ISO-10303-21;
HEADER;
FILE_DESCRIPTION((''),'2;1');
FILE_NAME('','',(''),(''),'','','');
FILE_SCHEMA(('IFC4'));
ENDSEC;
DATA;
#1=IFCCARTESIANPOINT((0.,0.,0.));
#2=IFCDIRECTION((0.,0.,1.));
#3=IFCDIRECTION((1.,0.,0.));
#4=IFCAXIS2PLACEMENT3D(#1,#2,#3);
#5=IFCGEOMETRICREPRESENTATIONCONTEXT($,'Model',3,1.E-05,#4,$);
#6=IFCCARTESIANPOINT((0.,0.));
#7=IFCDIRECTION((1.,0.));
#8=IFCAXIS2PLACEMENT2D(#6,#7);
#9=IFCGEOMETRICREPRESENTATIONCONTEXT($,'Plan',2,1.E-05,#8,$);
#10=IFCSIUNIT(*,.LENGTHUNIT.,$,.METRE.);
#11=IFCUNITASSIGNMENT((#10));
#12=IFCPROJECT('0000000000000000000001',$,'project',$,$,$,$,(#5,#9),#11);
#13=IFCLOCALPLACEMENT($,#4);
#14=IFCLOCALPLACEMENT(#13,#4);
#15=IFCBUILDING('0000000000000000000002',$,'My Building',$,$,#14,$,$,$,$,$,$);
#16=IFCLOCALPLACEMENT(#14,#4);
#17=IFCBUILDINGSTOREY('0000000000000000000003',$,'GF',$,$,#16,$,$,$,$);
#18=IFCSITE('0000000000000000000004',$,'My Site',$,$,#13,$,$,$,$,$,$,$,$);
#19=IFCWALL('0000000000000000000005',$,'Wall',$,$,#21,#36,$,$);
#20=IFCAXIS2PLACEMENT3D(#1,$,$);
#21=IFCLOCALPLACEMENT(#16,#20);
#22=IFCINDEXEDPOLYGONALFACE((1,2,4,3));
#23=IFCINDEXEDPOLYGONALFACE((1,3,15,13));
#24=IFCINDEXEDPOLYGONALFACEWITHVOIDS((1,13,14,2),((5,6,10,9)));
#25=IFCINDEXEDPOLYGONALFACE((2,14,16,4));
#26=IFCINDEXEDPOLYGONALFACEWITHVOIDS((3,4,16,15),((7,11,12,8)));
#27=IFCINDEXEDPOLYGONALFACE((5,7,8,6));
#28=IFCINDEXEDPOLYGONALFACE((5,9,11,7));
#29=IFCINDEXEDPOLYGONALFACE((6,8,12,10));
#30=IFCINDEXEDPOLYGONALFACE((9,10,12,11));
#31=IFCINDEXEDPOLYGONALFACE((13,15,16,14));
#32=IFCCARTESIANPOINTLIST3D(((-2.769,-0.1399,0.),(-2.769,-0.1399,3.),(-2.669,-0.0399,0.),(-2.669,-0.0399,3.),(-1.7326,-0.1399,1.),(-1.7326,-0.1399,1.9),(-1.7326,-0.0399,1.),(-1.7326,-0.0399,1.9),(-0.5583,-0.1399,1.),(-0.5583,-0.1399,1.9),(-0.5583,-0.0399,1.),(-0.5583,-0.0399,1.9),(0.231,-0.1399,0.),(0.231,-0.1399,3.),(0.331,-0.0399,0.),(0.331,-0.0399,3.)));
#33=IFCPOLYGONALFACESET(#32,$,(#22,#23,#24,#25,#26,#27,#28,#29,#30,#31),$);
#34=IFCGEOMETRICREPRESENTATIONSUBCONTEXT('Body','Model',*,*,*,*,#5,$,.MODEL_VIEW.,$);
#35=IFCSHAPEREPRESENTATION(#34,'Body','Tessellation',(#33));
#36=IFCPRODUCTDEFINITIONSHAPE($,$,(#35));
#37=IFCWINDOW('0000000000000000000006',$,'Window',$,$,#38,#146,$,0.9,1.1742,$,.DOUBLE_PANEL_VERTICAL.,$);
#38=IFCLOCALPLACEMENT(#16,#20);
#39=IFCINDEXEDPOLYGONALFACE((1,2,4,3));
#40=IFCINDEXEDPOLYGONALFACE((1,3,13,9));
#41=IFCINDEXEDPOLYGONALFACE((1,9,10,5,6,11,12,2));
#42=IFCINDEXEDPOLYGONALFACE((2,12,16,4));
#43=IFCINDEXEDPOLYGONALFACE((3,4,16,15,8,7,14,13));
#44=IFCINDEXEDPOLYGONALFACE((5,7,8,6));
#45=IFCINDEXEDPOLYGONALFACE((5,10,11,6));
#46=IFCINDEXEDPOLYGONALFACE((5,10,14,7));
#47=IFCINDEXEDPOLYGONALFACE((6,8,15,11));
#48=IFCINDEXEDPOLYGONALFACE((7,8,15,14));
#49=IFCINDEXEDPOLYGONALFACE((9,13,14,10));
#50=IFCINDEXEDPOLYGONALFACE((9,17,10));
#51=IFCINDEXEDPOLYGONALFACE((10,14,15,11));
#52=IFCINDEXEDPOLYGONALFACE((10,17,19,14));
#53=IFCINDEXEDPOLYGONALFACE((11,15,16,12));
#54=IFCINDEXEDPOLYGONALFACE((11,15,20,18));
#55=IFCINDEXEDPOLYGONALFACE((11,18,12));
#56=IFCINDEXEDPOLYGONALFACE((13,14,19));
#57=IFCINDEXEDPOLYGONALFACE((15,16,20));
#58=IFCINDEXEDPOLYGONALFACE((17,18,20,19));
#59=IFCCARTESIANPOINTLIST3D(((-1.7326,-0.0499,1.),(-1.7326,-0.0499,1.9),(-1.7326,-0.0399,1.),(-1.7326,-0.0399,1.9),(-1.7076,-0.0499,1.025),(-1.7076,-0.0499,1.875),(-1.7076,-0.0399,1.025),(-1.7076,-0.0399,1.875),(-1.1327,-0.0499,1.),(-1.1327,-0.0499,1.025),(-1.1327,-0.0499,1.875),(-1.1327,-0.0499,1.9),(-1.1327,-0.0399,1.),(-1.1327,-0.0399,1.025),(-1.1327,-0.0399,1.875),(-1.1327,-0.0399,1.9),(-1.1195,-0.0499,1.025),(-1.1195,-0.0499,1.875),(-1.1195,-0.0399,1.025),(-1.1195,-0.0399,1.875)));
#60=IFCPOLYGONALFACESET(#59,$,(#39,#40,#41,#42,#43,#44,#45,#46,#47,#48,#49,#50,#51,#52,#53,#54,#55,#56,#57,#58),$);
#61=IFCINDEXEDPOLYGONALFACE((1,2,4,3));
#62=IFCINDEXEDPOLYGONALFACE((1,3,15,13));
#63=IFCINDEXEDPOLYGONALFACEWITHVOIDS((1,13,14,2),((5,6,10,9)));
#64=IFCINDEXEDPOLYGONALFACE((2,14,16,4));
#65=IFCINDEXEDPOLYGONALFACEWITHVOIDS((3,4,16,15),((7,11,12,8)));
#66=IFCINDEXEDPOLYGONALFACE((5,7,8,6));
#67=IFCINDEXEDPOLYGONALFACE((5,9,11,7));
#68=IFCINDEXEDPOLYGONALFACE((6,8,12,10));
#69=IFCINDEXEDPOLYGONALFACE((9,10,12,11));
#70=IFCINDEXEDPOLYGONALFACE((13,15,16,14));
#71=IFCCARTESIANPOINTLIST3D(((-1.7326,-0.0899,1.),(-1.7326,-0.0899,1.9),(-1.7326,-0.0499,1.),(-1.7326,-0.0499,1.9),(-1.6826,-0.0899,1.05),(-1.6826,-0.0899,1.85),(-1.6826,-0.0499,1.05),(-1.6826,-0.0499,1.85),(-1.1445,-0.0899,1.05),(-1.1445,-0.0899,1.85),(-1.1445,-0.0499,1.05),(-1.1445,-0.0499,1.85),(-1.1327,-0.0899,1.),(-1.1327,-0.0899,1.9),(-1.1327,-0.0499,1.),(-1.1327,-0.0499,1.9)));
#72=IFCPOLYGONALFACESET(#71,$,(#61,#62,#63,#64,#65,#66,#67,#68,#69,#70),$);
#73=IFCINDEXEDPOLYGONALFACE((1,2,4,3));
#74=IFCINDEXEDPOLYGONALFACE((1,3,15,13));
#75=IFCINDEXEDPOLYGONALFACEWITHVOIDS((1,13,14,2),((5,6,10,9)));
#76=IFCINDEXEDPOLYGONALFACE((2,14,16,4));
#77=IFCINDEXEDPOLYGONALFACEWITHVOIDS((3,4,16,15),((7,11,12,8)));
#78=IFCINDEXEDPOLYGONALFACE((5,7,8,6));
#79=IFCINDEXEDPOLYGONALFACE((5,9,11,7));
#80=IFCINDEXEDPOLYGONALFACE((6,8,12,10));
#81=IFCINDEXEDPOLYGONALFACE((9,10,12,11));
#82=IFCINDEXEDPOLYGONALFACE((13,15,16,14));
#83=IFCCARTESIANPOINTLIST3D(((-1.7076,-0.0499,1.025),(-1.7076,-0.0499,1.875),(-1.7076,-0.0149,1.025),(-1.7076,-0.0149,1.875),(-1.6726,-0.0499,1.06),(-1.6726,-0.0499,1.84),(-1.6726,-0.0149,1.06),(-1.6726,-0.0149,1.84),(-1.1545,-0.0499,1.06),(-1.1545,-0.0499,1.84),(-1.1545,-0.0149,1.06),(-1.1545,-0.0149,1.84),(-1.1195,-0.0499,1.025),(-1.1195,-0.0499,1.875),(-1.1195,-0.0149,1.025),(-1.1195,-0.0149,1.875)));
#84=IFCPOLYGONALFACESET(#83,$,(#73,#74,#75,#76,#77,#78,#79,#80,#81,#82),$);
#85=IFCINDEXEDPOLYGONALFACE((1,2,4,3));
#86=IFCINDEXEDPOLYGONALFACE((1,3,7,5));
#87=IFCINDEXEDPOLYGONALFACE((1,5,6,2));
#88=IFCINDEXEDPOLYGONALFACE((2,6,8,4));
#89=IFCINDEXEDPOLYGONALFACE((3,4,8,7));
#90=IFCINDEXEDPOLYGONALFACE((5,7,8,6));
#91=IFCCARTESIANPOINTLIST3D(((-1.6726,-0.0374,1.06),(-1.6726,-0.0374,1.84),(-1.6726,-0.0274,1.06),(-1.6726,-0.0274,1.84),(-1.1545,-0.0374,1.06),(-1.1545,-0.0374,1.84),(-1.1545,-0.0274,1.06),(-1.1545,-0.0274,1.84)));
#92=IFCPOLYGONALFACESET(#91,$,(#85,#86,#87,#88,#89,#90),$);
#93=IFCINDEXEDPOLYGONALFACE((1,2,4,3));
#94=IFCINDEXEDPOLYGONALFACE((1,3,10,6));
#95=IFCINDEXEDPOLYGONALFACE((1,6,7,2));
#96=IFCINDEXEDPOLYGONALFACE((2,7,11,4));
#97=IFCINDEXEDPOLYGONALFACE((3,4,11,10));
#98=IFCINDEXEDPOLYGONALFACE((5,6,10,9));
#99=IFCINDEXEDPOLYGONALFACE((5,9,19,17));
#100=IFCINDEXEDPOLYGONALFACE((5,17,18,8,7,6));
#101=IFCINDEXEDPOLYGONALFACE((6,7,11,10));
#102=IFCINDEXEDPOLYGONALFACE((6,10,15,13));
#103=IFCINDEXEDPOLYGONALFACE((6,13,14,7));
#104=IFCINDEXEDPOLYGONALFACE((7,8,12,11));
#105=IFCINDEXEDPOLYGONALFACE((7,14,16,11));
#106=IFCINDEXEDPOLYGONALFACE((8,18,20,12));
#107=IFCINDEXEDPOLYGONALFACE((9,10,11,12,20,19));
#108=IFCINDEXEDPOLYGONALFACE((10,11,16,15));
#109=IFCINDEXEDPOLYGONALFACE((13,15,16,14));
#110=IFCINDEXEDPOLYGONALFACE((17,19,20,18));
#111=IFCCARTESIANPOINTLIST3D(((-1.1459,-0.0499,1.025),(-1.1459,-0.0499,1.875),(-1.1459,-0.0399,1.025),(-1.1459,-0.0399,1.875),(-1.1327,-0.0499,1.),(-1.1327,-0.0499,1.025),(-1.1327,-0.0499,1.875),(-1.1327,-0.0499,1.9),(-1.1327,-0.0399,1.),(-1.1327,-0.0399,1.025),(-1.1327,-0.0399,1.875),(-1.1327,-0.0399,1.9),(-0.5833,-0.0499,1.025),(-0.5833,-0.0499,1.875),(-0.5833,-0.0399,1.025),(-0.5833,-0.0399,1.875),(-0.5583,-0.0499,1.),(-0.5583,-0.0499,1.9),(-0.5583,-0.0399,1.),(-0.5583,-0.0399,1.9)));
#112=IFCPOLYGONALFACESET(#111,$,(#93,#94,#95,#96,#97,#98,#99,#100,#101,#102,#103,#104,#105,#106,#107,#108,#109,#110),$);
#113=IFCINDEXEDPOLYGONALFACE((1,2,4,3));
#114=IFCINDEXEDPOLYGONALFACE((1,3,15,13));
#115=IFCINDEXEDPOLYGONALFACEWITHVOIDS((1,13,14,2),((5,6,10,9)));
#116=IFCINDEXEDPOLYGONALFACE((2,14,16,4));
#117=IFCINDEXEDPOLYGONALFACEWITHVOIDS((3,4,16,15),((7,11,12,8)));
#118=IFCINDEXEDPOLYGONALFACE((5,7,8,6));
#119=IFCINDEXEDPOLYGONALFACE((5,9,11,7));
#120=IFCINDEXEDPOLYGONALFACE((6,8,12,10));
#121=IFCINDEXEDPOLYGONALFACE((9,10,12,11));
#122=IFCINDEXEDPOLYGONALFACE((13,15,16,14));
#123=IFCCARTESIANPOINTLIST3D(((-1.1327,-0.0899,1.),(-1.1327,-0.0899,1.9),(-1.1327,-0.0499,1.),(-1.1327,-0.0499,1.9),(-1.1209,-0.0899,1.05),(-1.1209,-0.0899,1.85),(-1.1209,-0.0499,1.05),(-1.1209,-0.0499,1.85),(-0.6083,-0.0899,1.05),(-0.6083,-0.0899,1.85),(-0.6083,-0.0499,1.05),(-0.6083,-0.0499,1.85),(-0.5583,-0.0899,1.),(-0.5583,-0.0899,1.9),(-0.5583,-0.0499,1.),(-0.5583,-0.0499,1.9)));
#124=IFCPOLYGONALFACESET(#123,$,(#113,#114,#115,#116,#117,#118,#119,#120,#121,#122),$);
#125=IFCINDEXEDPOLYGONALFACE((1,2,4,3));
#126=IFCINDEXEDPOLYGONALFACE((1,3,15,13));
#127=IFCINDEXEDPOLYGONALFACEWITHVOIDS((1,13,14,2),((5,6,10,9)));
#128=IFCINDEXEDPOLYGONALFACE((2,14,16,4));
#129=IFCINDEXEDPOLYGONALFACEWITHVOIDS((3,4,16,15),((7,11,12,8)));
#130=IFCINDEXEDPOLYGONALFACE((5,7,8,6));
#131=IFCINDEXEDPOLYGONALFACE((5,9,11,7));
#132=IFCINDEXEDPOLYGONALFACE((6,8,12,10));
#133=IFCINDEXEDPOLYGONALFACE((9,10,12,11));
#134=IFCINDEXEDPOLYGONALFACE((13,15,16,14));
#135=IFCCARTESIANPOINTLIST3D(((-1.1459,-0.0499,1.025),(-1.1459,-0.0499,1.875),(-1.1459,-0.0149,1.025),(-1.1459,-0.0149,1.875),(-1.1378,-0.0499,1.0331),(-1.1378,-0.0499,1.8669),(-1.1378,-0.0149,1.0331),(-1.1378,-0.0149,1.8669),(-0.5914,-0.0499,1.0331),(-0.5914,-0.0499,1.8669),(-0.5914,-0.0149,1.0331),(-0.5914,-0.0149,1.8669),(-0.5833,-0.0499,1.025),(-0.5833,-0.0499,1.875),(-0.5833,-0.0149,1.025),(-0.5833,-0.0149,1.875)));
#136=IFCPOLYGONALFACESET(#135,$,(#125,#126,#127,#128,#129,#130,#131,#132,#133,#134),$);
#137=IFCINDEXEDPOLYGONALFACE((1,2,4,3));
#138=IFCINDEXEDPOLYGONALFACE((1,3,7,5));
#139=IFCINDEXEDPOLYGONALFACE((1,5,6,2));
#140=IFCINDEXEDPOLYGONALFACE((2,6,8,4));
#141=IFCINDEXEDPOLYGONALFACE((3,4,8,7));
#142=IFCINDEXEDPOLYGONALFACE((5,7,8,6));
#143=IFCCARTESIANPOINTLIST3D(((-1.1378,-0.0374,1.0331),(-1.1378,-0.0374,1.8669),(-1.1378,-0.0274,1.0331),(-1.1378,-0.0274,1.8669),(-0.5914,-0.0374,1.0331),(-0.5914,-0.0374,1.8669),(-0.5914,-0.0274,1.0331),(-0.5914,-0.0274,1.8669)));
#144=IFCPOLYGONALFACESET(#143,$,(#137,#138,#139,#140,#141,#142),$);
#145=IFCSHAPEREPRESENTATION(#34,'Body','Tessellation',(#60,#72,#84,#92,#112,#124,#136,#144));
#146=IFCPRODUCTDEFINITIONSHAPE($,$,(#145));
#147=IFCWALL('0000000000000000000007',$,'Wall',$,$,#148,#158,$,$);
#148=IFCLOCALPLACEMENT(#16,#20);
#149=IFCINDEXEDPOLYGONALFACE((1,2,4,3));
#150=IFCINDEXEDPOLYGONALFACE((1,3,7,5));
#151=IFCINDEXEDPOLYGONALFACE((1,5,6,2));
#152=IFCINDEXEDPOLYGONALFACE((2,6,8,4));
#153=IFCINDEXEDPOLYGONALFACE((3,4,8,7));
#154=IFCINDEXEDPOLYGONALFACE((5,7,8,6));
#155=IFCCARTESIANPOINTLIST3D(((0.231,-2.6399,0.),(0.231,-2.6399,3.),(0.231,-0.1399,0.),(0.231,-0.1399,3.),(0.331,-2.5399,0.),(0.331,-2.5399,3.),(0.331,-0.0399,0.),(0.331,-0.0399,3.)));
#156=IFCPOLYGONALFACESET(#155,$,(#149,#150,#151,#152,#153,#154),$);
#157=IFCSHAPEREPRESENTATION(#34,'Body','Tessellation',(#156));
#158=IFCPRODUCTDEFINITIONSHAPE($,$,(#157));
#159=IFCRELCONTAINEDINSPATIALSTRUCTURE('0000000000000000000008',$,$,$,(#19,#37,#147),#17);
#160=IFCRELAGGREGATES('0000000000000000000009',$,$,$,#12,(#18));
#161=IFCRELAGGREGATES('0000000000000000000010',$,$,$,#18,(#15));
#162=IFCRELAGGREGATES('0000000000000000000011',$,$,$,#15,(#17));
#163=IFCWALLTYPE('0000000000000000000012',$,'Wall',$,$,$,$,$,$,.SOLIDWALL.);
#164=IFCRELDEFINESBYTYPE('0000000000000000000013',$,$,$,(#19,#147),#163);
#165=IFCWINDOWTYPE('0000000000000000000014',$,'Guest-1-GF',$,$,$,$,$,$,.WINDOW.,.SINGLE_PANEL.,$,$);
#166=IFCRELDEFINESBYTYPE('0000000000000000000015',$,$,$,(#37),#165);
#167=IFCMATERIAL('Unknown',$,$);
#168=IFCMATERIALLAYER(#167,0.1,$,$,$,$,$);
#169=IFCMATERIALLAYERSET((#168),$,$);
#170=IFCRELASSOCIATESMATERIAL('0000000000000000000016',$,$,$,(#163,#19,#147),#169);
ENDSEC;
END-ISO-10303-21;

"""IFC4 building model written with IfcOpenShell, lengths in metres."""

from ifc_helpers import new_model, entity, si_unit, frame, origin_with_axes, origin_2d_with_axis, place, context, subcontext, project, spatial, line, indexed_curve, outline, extrude, shape, source, transform, mapped, material, layer, layer_set, layer_usage, type_object, type_shapes, element, fill, save


model = new_model("IFC4")

# Units and contexts
model_context = context("Model", 3, precision=1e-05, world=origin_with_axes())
plan_context = context("Plan", 2, precision=1e-05, world=origin_2d_with_axis())
body_context_1 = subcontext(model_context, "Body", "Model", "MODEL_VIEW")
body_context_2 = subcontext(plan_context, "Body", "Plan", "PLAN_VIEW")
ifc_project = project(units=[si_unit("LENGTHUNIT", "METRE")], contexts=[model_context, plan_context])

# Site, building, storey
site_placement = place(None, origin_with_axes())
site = spatial("IfcSite", under=ifc_project, at=site_placement, Name="My Site")
building_placement = place(site_placement, origin_with_axes())
building = spatial("IfcBuilding", under=site, at=building_placement, Name="My Building")
storey_placement = place(building_placement, origin_with_axes())
storey = spatial("IfcBuildingStorey", under=building, at=storey_placement, Name="GF")

# Shared definitions
ifc_material_1 = material(Name="Unknown")

# Shared definitions
ifc_layer_1 = layer(ifc_material_1, 0.1)
ifc_layer_set_1 = layer_set([ifc_layer_1])
wall_type = type_object("IfcWallType", Name="Wall", PredefinedType="SOLIDWALL", material=ifc_layer_set_1)

# Wall, opening, window
ifc_layer_usage_1 = layer_usage(ifc_layer_set_1, "AXIS2", "POSITIVE", 0.0)
wall_1_placement = place(storey_placement, frame((-2.769, -0.1399, 0.0), z_axis=(0.0, 0.0, 1.0), x_axis=(1.0, 0.0, 0.0)))
wall_1 = element("IfcWall", 1, at=wall_1_placement, inside=storey, type_object=wall_type, material=ifc_layer_usage_1, Name="Wall", context=body_context_1, shape_type="SweptSolid", body=[
    extrude(outline(indexed_curve([(0.0, 0.0), (0.1, 0.1), (3.1, 0.1), (3.0, 0.0)], segments=[line(1, 2, 3, 4, 1)])), origin_with_axes(), (0.0, 0.0, 1.0), 3.0),
])
shared_shape_1 = source(origin_with_axes(), body_context_1, "Body", "SweptSolid", [
    extrude(outline(indexed_curve([(0.0, 0.0), (1.1742, 0.0), (1.1742, 0.9), (0.0, 0.9)], segments=[line(1, 2, 3, 4, 1)])), frame((0.0, -0.6, 0.0), z_axis=(0.0, -1.0, 0.0), x_axis=(1.0, 0.0, 0.0)), (0.0, 0.0, -1.0), 1.2),
])
opening_1_placement = place(wall_1_placement, frame((1.0365, 0.0, 1.0), z_axis=(0.0, 0.0, 1.0), x_axis=(1.0, 0.0, 0.0)))
opening_1 = element("IfcOpeningElement", 2, at=opening_1_placement, cuts=wall_1, PredefinedType="OPENING", context=body_context_1, shape_type="MappedRepresentation", body=[
    mapped(shared_shape_1, transform((0.0, 0.0, 0.0), x_axis=(1.0, 0.0, 0.0), y_axis=(0.0, 1.0, 0.0), z_axis=(0.0, 0.0, 1.0), scale=1.0)),
])
window_type_1 = type_object("IfcWindowType", Name="Guest-1-GF", PartitioningType="SINGLE_PANEL", PredefinedType="WINDOW")
shared_shape_2 = source(origin_with_axes(), body_context_1, "Body", "SweptSolid", [
    extrude(outline(indexed_curve([(0.0, 0.0), (0.5999, 0.0), (0.5999, 0.9), (0.0, 0.9)], segments=[line(1, 2, 3, 4, 1)]), holes=[indexed_curve([(0.025, 0.025), (0.6131, 0.025), (0.6131, 0.875), (0.025, 0.875)], segments=[line(1, 2, 3, 4, 1)])]), frame((0.0, 0.09, 0.0), z_axis=(0.0, -1.0, 0.0), x_axis=(1.0, 0.0, 0.0)), (0.0, 0.0, -1.0), 0.01),
    extrude(outline(indexed_curve([(0.0, 0.0), (0.5999, 0.0), (0.5999, 0.9), (0.0, 0.9)], segments=[line(1, 2, 3, 4, 1)]), holes=[indexed_curve([(0.05, 0.05), (0.5881, 0.05), (0.5881, 0.85), (0.05, 0.85)], segments=[line(1, 2, 3, 4, 1)])]), frame((0.0, 0.05, 0.0), z_axis=(0.0, -1.0, 0.0), x_axis=(1.0, 0.0, 0.0)), (0.0, 0.0, -1.0), 0.04),
    extrude(outline(indexed_curve([(0.0, 0.0), (0.5881, 0.0), (0.5881, 0.85), (0.0, 0.85)], segments=[line(1, 2, 3, 4, 1)]), holes=[indexed_curve([(0.035, 0.035), (0.5531, 0.035), (0.5531, 0.815), (0.035, 0.815)], segments=[line(1, 2, 3, 4, 1)])]), frame((0.025, 0.09, 0.025), z_axis=(0.0, -1.0, 0.0), x_axis=(1.0, 0.0, 0.0)), (0.0, 0.0, -1.0), 0.035),
    extrude(outline(indexed_curve([(0.035, 0.035), (0.5531, 0.035), (0.5531, 0.815), (0.035, 0.815)], segments=[line(1, 2, 3, 4, 1)])), frame((0.025, 0.1025, 0.025), z_axis=(0.0, -1.0, 0.0), x_axis=(1.0, 0.0, 0.0)), (0.0, 0.0, -1.0), 0.01),
    extrude(outline(indexed_curve([(0.0, 0.0), (0.5744, 0.0), (0.5744, 0.9), (0.0, 0.9)], segments=[line(1, 2, 3, 4, 1)]), holes=[indexed_curve([(-0.0132, 0.025), (0.5494, 0.025), (0.5494, 0.875), (-0.0132, 0.875)], segments=[line(1, 2, 3, 4, 1)])]), frame((0.5999, 0.09, 0.0), z_axis=(0.0, -1.0, 0.0), x_axis=(1.0, 0.0, 0.0)), (0.0, 0.0, -1.0), 0.01),
    extrude(outline(indexed_curve([(0.0, 0.0), (0.5744, 0.0), (0.5744, 0.9), (0.0, 0.9)], segments=[line(1, 2, 3, 4, 1)]), holes=[indexed_curve([(0.0118, 0.05), (0.5244, 0.05), (0.5244, 0.85), (0.0118, 0.85)], segments=[line(1, 2, 3, 4, 1)])]), frame((0.5999, 0.05, 0.0), z_axis=(0.0, -1.0, 0.0), x_axis=(1.0, 0.0, 0.0)), (0.0, 0.0, -1.0), 0.04),
    extrude(outline(indexed_curve([(0.0, 0.0), (0.5626, 0.0), (0.5626, 0.85), (0.0, 0.85)], segments=[line(1, 2, 3, 4, 1)]), holes=[indexed_curve([(0.0081, 0.0081), (0.5545, 0.0081), (0.5545, 0.8419), (0.0081, 0.8419)], segments=[line(1, 2, 3, 4, 1)])]), frame((0.5866, 0.09, 0.025), z_axis=(0.0, -1.0, 0.0), x_axis=(1.0, 0.0, 0.0)), (0.0, 0.0, -1.0), 0.035),
    extrude(outline(indexed_curve([(0.0081, 0.0081), (0.5545, 0.0081), (0.5545, 0.8419), (0.0081, 0.8419)], segments=[line(1, 2, 3, 4, 1)])), frame((0.5866, 0.1025, 0.025), z_axis=(0.0, -1.0, 0.0), x_axis=(1.0, 0.0, 0.0)), (0.0, 0.0, -1.0), 0.01),
])
shared_shape_3 = source(origin_with_axes(), body_context_2, "Body", "Curve2D", [
    entity("IfcIndexedPolyCurve", entity("IfcCartesianPointList2D", [[0.05, 0.05], [0.5881, 0.05]])),
    entity("IfcIndexedPolyCurve", entity("IfcCartesianPointList2D", [[0.0, 0.1], [0.025, 0.1], [0.025, 0.09], [0.05, 0.09], [0.05, 0.05], [0.0, 0.05]]), [entity("IfcLineIndex", [1, 2, 3, 4, 5, 6, 1])]),
    entity("IfcIndexedPolyCurve", entity("IfcCartesianPointList2D", [[0.5999, 0.1], [0.6131, 0.1], [0.6131, 0.09], [0.5881, 0.09], [0.5881, 0.05], [0.5999, 0.05]])),
    entity("IfcIndexedPolyCurve", entity("IfcCartesianPointList2D", [[0.025, 0.09], [0.06, 0.09], [0.06, 0.125], [0.025, 0.125]]), [entity("IfcLineIndex", [1, 2, 3, 4, 1])]),
    entity("IfcIndexedPolyCurve", entity("IfcCartesianPointList2D", [[0.6131, 0.09], [0.5781, 0.09], [0.5781, 0.125], [0.6131, 0.125]]), [entity("IfcLineIndex", [1, 2, 3, 4, 1])]),
    entity("IfcIndexedPolyCurve", entity("IfcCartesianPointList2D", [[0.06, 0.09], [0.5781, 0.09]])),
    entity("IfcIndexedPolyCurve", entity("IfcCartesianPointList2D", [[0.06, 0.125], [0.5781, 0.125]])),
    entity("IfcIndexedPolyCurve", entity("IfcCartesianPointList2D", [[0.06, 0.1075], [0.5781, 0.1075]])),
    entity("IfcIndexedPolyCurve", entity("IfcCartesianPointList2D", [[0.6116, 0.05], [1.1242, 0.05]])),
    entity("IfcIndexedPolyCurve", entity("IfcCartesianPointList2D", [[0.5999, 0.1], [0.5866, 0.1], [0.5866, 0.09], [0.6116, 0.09], [0.6116, 0.05], [0.5999, 0.05]])),
    entity("IfcIndexedPolyCurve", entity("IfcCartesianPointList2D", [[1.1742, 0.1], [1.1492, 0.1], [1.1492, 0.09], [1.1242, 0.09], [1.1242, 0.05], [1.1742, 0.05]]), [entity("IfcLineIndex", [1, 2, 3, 4, 5, 6, 1])]),
    entity("IfcIndexedPolyCurve", entity("IfcCartesianPointList2D", [[0.5866, 0.09], [0.5947, 0.09], [0.5947, 0.125], [0.5866, 0.125]]), [entity("IfcLineIndex", [1, 2, 3, 4, 1])]),
    entity("IfcIndexedPolyCurve", entity("IfcCartesianPointList2D", [[1.1492, 0.09], [1.1412, 0.09], [1.1412, 0.125], [1.1492, 0.125]]), [entity("IfcLineIndex", [1, 2, 3, 4, 1])]),
    entity("IfcIndexedPolyCurve", entity("IfcCartesianPointList2D", [[0.5947, 0.09], [1.1412, 0.09]])),
    entity("IfcIndexedPolyCurve", entity("IfcCartesianPointList2D", [[0.5947, 0.125], [1.1412, 0.125]])),
    entity("IfcIndexedPolyCurve", entity("IfcCartesianPointList2D", [[0.5947, 0.1075], [1.1412, 0.1075]])),
])
type_shapes(window_type_1, [shared_shape_2, shared_shape_3])
window_1_placement = place(opening_1_placement, origin_with_axes())
window_1 = element("IfcWindow", 3, at=window_1_placement, inside=storey, type_object=window_type_1, Name="Window", OverallHeight=0.9, OverallWidth=1.1742, PartitioningType="DOUBLE_PANEL_VERTICAL", shapes=[
    shape(body_context_1, "Body", "MappedRepresentation", [mapped(shared_shape_2, transform((0.0, 0.0, 0.0), x_axis=(1.0, 0.0, 0.0), y_axis=(0.0, 1.0, 0.0), z_axis=(0.0, 0.0, 1.0), scale=1.0))]),
    shape(body_context_2, "Body", "MappedRepresentation", [mapped(shared_shape_3, transform((0.0, 0.0, 0.0), x_axis=(1.0, 0.0, 0.0), y_axis=(0.0, 1.0, 0.0), z_axis=(0.0, 0.0, 1.0), scale=1.0))]),
])
fill(opening_1, window_1)

# Wall
ifc_layer_usage_2 = layer_usage(ifc_layer_set_1, "AXIS2", "POSITIVE", 0.0)
wall_2_placement = place(storey_placement, frame((0.231, -0.1399, 0.0), z_axis=(0.0, 0.0, 1.0), x_axis=(0.0, -1.0, 0.0)))
element("IfcWall", 4, at=wall_2_placement, inside=storey, type_object=wall_type, material=ifc_layer_usage_2, Name="Wall", context=body_context_1, shape_type="SweptSolid", body=[
    extrude(outline(indexed_curve([(0.0, 0.0), (-0.1, 0.1), (2.4, 0.1), (2.5, 0.0)], segments=[line(1, 2, 3, 4, 1)])), origin_with_axes(), (0.0, 0.0, 1.0), 3.0),
])

save(model, "model.ifc")
